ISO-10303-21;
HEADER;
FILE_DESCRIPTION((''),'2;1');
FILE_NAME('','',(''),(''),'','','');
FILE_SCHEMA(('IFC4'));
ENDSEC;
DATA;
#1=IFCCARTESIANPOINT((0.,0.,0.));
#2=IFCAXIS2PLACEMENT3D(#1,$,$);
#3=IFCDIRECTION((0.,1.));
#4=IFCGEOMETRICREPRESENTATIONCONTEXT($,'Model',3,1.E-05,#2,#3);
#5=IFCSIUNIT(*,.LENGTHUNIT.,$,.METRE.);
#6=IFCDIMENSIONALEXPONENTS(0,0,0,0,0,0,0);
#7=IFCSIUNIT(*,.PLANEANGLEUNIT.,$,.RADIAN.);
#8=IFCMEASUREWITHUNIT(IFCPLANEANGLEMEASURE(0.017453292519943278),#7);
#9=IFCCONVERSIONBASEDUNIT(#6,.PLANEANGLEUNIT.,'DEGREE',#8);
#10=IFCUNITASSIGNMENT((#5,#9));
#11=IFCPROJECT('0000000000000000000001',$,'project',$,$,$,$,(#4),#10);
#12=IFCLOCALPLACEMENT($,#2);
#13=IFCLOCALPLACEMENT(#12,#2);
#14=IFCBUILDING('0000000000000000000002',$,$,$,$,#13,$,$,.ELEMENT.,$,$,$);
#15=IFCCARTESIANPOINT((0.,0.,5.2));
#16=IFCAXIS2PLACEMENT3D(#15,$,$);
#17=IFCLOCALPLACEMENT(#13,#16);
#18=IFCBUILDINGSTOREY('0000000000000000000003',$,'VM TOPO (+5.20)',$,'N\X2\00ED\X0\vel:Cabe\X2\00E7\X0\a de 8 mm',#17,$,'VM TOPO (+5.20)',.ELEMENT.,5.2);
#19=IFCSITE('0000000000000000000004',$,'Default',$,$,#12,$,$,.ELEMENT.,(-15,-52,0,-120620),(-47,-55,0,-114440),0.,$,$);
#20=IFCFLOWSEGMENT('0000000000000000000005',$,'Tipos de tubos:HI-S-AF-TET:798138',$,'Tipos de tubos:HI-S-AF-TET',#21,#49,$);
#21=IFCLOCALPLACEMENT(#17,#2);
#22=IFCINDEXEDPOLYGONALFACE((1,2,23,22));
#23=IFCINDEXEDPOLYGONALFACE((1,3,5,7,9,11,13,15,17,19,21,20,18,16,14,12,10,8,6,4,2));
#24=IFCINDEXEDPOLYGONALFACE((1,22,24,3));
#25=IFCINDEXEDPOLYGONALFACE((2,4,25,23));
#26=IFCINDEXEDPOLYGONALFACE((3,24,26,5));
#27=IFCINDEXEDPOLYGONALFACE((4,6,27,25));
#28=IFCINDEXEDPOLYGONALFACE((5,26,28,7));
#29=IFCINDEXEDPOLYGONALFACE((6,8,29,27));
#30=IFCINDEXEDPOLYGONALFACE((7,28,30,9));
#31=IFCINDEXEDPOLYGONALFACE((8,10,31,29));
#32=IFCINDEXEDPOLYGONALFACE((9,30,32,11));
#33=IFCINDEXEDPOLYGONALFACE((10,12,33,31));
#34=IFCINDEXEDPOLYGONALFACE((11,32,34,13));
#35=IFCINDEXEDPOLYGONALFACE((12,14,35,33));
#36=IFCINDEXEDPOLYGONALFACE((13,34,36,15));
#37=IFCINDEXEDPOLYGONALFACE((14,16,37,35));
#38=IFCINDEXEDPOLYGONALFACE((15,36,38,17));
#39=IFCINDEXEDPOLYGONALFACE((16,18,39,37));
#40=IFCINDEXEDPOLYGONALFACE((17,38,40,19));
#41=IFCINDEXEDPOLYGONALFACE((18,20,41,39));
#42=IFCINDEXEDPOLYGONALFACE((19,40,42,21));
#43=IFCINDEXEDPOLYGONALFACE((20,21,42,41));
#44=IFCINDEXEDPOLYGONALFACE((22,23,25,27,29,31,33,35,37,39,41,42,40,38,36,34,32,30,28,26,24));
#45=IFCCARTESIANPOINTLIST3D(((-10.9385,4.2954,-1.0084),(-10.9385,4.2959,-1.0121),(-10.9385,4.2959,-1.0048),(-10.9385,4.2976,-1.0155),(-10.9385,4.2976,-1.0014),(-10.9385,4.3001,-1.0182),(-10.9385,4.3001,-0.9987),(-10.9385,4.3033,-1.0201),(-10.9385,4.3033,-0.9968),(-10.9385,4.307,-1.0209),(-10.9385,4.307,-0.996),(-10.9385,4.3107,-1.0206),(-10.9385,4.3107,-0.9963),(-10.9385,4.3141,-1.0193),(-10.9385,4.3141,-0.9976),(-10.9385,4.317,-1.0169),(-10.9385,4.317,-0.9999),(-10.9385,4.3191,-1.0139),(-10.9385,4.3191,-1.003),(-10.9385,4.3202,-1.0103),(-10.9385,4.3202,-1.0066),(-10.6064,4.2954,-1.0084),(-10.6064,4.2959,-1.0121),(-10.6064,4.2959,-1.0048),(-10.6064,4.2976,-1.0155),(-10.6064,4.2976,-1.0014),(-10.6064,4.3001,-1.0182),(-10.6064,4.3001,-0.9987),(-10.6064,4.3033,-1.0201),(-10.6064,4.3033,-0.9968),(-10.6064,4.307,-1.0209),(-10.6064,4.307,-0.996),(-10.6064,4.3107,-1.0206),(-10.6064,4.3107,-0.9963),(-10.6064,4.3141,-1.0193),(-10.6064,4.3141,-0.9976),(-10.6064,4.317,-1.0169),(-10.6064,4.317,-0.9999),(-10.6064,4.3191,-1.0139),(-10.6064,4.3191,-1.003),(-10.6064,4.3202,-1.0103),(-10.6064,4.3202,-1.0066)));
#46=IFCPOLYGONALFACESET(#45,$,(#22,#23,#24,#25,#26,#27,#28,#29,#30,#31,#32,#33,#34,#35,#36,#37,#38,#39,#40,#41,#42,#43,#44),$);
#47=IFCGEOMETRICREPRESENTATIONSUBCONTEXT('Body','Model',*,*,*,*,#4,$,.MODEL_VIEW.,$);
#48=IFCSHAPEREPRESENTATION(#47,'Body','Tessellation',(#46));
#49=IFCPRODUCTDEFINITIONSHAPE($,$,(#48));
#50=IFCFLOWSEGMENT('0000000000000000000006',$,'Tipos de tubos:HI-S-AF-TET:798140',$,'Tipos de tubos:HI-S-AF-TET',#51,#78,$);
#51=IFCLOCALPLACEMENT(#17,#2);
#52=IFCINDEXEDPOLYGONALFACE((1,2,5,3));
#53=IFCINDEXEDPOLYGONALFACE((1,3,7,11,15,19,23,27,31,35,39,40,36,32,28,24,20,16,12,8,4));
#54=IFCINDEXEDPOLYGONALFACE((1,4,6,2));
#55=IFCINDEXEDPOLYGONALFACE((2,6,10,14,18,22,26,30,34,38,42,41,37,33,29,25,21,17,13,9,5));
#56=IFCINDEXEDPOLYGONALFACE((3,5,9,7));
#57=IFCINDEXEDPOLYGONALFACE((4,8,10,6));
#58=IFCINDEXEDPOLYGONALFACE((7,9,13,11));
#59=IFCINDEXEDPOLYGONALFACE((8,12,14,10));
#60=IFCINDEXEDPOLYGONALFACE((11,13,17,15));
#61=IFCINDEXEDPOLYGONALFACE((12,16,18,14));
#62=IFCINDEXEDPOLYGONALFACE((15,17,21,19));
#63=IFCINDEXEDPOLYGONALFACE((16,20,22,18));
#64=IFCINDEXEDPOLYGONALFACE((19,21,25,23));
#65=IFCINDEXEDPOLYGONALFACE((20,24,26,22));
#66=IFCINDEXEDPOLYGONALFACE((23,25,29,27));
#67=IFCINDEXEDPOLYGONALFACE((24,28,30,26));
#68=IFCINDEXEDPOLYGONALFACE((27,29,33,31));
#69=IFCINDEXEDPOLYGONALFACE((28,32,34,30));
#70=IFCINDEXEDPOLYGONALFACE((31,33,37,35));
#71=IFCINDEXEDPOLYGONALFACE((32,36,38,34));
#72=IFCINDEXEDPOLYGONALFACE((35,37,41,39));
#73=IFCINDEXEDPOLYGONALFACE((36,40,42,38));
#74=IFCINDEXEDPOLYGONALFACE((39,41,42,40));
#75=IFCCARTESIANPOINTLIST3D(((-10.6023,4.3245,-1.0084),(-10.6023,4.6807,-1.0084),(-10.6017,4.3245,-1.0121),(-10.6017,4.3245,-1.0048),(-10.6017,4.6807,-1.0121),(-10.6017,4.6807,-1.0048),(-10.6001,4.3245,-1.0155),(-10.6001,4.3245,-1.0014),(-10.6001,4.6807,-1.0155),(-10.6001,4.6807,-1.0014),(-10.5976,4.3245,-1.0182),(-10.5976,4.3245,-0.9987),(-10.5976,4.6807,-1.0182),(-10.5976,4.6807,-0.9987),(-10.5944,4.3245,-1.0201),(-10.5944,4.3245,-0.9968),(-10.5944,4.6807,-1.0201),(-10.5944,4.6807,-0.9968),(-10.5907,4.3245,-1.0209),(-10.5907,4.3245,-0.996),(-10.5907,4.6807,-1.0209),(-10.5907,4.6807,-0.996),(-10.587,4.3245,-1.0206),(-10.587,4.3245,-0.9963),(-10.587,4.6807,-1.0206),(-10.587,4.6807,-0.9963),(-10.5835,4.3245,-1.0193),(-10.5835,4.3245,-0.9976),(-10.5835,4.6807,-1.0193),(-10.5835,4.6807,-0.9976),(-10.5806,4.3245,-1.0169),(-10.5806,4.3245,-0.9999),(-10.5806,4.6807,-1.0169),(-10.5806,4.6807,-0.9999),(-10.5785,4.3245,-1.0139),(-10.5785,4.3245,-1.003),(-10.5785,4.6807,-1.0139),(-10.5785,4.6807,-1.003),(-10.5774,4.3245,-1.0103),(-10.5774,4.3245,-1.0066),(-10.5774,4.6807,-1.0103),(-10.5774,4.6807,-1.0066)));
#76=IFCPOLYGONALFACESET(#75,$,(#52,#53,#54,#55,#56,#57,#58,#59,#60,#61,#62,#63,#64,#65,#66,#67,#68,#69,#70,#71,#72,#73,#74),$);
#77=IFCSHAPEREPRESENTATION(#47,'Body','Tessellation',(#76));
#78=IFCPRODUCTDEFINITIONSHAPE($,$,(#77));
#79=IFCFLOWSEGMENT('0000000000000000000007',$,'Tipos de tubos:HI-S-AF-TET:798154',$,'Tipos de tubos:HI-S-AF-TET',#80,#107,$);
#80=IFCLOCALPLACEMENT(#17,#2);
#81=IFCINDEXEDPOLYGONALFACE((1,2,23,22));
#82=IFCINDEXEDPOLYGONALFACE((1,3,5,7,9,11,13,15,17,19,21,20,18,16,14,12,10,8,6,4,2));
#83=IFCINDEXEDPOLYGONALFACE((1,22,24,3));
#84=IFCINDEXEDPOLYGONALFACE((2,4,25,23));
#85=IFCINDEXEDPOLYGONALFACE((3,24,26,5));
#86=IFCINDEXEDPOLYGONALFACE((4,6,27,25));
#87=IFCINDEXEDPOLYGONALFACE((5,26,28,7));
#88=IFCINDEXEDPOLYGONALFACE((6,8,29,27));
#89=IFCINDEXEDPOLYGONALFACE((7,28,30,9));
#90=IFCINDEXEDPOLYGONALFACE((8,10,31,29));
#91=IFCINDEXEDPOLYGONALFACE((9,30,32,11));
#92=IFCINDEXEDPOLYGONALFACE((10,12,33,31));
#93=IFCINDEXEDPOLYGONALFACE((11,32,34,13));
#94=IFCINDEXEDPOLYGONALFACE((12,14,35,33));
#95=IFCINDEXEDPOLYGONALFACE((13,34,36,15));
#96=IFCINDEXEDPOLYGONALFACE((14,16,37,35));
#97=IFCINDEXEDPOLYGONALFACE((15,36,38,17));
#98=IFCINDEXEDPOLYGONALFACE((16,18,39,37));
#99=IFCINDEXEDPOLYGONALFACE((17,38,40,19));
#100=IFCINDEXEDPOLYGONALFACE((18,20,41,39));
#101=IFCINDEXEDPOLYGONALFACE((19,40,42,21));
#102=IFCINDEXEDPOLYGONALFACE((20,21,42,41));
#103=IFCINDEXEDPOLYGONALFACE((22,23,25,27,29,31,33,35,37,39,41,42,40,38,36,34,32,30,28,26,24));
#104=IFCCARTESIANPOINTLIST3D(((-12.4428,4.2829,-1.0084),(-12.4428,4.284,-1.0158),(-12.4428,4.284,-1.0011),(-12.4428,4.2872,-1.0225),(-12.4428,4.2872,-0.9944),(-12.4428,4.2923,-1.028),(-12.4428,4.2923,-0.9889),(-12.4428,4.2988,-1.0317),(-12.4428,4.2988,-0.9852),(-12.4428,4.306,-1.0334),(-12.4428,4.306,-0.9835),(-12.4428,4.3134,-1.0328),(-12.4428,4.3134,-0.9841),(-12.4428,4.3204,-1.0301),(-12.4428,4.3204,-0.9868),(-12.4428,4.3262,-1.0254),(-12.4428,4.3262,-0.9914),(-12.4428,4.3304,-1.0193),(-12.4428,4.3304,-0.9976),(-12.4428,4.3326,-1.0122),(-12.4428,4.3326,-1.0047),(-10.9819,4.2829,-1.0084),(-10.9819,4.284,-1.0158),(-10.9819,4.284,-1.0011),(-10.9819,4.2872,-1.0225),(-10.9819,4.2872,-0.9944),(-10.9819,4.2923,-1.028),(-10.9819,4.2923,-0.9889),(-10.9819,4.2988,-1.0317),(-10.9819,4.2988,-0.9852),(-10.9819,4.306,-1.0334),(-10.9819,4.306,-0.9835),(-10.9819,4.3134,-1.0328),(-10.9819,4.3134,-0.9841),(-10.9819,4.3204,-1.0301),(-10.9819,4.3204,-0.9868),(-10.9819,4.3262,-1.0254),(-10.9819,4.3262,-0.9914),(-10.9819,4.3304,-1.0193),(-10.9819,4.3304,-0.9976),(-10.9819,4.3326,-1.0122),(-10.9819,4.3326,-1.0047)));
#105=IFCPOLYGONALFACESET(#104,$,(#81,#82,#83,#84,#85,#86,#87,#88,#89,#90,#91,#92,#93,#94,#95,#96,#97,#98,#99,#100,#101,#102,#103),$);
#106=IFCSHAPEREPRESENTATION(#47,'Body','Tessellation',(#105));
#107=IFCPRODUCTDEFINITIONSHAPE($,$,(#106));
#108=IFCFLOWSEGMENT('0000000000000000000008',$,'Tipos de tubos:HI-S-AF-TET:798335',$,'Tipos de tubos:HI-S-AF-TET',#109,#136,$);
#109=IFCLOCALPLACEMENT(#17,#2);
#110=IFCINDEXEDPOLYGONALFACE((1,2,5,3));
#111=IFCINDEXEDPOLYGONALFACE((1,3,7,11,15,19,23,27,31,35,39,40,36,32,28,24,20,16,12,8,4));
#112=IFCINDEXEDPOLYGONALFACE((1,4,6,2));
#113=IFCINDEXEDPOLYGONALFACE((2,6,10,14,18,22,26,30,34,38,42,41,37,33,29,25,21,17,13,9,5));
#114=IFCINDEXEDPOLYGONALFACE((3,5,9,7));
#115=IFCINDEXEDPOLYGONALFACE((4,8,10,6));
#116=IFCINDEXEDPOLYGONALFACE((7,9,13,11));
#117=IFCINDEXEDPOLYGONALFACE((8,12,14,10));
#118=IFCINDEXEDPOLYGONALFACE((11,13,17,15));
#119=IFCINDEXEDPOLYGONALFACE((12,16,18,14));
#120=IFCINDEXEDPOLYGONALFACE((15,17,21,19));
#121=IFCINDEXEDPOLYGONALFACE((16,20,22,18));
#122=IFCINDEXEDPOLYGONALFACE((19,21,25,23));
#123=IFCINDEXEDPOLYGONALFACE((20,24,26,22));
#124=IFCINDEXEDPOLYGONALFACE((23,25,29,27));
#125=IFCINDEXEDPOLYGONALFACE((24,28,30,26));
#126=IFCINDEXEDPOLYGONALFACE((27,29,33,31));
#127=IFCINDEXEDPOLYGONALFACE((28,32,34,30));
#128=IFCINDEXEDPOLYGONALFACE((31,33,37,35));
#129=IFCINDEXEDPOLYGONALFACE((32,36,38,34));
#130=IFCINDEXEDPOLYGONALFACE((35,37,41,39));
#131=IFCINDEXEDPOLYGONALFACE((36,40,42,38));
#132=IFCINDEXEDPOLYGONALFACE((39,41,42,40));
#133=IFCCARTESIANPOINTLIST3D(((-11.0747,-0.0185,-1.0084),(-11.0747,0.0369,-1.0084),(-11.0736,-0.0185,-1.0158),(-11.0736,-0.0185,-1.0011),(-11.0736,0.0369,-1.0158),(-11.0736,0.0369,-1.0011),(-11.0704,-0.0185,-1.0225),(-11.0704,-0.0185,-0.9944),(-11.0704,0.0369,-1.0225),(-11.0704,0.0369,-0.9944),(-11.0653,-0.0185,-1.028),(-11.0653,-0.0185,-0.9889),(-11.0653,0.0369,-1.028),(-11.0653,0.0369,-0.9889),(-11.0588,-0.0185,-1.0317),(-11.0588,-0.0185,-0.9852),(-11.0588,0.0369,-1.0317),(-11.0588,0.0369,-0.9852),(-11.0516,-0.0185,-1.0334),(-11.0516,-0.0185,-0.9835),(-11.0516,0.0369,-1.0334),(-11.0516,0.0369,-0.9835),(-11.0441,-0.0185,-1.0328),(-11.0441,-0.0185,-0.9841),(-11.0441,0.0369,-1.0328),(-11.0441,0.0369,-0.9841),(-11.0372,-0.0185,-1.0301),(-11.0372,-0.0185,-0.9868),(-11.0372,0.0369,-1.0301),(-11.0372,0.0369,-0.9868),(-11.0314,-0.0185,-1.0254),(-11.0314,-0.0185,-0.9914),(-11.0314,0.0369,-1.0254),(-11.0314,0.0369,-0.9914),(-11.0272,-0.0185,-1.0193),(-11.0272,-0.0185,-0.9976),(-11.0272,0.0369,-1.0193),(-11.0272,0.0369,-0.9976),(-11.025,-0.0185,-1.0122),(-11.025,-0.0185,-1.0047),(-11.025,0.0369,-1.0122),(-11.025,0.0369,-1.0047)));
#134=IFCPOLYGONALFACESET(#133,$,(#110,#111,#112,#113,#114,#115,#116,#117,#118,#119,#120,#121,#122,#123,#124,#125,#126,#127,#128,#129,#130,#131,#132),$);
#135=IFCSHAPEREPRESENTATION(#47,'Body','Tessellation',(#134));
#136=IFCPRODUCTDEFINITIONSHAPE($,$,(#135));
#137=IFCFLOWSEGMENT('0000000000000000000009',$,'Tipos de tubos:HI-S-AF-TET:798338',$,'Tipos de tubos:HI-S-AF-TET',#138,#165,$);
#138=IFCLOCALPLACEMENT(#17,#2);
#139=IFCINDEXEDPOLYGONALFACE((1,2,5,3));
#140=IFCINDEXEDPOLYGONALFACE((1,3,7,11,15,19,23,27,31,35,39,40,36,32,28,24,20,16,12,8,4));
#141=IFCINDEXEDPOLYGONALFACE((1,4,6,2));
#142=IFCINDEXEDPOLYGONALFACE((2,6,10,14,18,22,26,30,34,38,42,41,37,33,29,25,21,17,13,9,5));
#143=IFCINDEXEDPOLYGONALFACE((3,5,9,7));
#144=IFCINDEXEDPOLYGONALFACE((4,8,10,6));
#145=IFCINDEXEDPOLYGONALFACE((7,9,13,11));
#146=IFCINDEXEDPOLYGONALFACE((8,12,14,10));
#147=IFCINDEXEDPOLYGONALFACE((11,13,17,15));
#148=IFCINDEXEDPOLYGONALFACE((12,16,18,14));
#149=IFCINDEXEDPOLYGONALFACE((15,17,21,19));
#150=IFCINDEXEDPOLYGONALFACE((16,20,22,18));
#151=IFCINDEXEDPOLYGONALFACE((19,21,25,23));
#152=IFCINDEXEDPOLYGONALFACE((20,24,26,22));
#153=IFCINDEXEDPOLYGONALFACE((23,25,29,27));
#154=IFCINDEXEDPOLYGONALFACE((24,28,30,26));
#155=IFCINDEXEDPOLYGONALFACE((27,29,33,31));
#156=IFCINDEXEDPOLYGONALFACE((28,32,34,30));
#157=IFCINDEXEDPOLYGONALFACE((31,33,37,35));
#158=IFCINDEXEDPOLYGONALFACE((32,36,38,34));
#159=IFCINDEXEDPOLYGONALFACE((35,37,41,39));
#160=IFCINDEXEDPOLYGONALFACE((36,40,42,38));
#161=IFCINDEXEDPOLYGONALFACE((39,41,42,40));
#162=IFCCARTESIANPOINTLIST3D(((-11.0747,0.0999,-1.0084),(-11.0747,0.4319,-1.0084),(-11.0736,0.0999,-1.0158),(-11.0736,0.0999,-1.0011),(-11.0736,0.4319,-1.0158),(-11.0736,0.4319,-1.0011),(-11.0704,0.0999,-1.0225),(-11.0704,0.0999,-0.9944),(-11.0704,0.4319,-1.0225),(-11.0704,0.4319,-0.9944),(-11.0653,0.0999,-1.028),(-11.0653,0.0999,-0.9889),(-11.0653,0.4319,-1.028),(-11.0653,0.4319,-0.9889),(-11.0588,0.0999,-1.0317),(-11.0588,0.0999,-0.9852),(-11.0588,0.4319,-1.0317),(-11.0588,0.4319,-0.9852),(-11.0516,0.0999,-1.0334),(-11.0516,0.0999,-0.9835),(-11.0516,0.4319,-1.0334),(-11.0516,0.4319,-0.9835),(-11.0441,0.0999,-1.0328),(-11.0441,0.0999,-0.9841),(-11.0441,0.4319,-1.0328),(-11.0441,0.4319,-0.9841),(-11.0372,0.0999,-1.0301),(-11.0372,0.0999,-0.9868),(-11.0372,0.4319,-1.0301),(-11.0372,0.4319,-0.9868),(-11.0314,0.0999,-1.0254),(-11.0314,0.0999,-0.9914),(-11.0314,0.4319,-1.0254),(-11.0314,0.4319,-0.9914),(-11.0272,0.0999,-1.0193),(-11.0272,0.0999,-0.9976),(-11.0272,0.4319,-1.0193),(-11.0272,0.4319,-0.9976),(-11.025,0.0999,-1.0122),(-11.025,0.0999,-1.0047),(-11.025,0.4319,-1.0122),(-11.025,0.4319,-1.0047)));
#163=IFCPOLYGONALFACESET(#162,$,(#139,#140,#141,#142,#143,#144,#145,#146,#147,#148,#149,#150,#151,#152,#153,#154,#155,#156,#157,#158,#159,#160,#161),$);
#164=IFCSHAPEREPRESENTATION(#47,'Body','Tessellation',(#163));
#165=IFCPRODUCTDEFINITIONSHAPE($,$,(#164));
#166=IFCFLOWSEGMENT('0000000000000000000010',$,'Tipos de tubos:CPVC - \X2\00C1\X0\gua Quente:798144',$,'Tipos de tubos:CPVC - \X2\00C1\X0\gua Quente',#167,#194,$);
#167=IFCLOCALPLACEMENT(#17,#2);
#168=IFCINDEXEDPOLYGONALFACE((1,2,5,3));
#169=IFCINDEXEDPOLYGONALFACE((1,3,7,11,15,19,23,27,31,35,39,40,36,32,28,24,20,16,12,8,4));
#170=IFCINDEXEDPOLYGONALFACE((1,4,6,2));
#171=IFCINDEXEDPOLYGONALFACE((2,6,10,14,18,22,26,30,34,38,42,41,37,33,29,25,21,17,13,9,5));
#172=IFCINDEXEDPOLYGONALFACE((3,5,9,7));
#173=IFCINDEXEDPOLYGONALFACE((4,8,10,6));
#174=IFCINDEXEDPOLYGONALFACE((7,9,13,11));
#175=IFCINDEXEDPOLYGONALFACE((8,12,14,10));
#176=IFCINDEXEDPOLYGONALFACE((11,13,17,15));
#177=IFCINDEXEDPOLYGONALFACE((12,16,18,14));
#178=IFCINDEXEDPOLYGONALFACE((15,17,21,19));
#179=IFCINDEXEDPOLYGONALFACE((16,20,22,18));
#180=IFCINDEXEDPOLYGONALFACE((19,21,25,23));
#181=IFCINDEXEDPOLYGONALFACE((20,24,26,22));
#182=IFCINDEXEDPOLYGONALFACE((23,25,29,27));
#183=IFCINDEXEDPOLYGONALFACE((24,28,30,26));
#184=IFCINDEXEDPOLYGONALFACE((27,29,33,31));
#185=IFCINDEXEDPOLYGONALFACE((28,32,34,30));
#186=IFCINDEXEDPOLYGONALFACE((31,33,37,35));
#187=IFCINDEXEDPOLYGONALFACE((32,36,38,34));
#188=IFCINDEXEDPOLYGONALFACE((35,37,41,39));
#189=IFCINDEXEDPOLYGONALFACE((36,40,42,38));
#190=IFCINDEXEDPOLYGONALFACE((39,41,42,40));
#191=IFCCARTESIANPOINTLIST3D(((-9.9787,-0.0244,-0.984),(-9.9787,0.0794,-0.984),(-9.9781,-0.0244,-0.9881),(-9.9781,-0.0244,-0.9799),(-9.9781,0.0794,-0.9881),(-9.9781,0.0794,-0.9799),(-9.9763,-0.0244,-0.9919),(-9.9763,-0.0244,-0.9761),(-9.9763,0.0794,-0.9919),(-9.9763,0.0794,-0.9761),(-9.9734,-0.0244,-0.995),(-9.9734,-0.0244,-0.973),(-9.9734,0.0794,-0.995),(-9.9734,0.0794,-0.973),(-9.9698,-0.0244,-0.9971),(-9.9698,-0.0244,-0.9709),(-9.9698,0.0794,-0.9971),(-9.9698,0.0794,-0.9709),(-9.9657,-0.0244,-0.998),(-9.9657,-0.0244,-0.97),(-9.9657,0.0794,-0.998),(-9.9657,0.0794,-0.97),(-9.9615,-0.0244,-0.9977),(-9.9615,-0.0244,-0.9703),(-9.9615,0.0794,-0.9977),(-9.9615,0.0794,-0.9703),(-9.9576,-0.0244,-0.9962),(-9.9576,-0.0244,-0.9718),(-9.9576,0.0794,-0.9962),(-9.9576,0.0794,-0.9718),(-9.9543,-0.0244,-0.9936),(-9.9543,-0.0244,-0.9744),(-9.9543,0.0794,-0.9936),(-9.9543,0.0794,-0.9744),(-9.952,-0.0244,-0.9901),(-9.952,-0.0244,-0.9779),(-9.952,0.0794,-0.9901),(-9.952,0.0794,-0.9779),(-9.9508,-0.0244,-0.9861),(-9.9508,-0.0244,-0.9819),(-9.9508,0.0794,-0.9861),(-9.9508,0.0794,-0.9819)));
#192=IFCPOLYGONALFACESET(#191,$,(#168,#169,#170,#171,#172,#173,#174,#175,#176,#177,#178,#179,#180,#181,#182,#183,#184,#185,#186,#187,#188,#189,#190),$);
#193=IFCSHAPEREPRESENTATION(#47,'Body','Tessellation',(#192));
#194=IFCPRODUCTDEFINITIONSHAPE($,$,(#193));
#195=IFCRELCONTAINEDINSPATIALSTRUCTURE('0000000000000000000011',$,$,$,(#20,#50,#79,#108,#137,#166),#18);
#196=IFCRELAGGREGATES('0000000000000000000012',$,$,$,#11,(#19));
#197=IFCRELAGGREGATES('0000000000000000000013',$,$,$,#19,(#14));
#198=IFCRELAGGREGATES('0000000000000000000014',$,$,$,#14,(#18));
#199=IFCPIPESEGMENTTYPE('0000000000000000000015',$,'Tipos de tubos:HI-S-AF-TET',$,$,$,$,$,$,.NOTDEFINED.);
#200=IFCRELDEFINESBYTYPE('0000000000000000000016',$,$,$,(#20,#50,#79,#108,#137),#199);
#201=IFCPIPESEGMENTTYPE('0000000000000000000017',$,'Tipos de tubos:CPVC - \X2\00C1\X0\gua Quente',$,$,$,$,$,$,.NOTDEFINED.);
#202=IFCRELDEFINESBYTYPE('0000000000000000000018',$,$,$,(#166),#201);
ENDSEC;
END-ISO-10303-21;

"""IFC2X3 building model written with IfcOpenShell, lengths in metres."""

from ifc_helpers import new_model, entity, si_unit, converted_unit, direction, frame, frame_2d, origin, origin_2d_with_axis, place, context, subcontext, project, spatial, circle, extrude, type_object, element, save


model = new_model("IFC2X3")

# Units and contexts
model_context = context("Model", 3, precision=1e-05, world=origin(), true_north=direction((0.0, 1.0)))
body_context = subcontext(model_context, "Body", "Model", "MODEL_VIEW")
ifc_project = project(units=[si_unit("LENGTHUNIT", "METRE"), converted_unit("PLANEANGLEUNIT", "DEGREE", entity("IfcPlaneAngleMeasure", 0.017453292519943278), si_unit("PLANEANGLEUNIT", "RADIAN"), dimensions=[0, 0, 0, 0, 0, 0, 0])], contexts=[model_context])

# Site, building, storey
site_placement = place(None, origin())
site = spatial("IfcSite", under=ifc_project, at=site_placement, Name="Default", CompositionType="ELEMENT", RefLatitude=(-15, -52, 0, -120620), RefLongitude=(-47, -55, 0, -114440), RefElevation=0.0)
building_placement = place(site_placement, origin())
building = spatial("IfcBuilding", under=site, at=building_placement, CompositionType="ELEMENT")
storey_placement = place(building_placement, frame((0.0, 0.0, 5.2)))
storey = spatial("IfcBuildingStorey", under=building, at=storey_placement, Name="VM TOPO (+5.20)", ObjectType="Nível:Cabeça de 8 mm", LongName="VM TOPO (+5.20)", CompositionType="ELEMENT", Elevation=5.2)

# Flow segments
pipe_segment_type_1 = type_object("IfcPipeSegmentType", Name="Tipos de tubos:HI-S-AF-TET", PredefinedType="NOTDEFINED")
flow_segment_1_placement = place(storey_placement, origin())
element("IfcFlowSegment", 1, at=flow_segment_1_placement, inside=storey, type_object=pipe_segment_type_1, Name="Tipos de tubos:HI-S-AF-TET:798138", ObjectType="Tipos de tubos:HI-S-AF-TET", context=body_context, shape_type="SweptSolid", body=[
    extrude(circle(Radius=0.0125, at=frame_2d((0.0, 0.0), x_axis=(1.0, 0.0))), frame((-10.9385, 4.3079, -1.0084), z_axis=(1.0, 0.0, 0.0), x_axis=(0.0, -1.0, 0.0)), (0.0, 0.0, 1.0), 0.3321),
])
flow_segment_2_placement = place(storey_placement, origin())
element("IfcFlowSegment", 2, at=flow_segment_2_placement, inside=storey, type_object=pipe_segment_type_1, Name="Tipos de tubos:HI-S-AF-TET:798140", ObjectType="Tipos de tubos:HI-S-AF-TET", context=body_context, shape_type="SweptSolid", body=[
    extrude(circle(Radius=0.0125, at=origin_2d_with_axis()), frame((-10.5898, 4.3245, -1.0084), z_axis=(0.0, 1.0, 0.0), x_axis=(-1.0, 0.0, 0.0)), (0.0, 0.0, 1.0), 0.3563),
])
flow_segment_3_placement = place(storey_placement, origin())
element("IfcFlowSegment", 3, at=flow_segment_3_placement, inside=storey, type_object=pipe_segment_type_1, Name="Tipos de tubos:HI-S-AF-TET:798154", ObjectType="Tipos de tubos:HI-S-AF-TET", context=body_context, shape_type="SweptSolid", body=[
    extrude(circle(Radius=0.025, at=origin_2d_with_axis()), frame((-12.4428, 4.3079, -1.0084), z_axis=(1.0, 0.0, 0.0), x_axis=(0.0, -1.0, 0.0)), (0.0, 0.0, 1.0), 1.4609),
])
flow_segment_4_placement = place(storey_placement, origin())
element("IfcFlowSegment", 4, at=flow_segment_4_placement, inside=storey, type_object=pipe_segment_type_1, Name="Tipos de tubos:HI-S-AF-TET:798335", ObjectType="Tipos de tubos:HI-S-AF-TET", context=body_context, shape_type="SweptSolid", body=[
    extrude(circle(Radius=0.025, at=frame_2d((0.0, 0.0), x_axis=(1.0, 0.0))), frame((-11.0497, -0.0185, -1.0084), z_axis=(0.0, 1.0, 0.0), x_axis=(-1.0, 0.0, 0.0)), (0.0, 0.0, 1.0), 0.0554),
])
flow_segment_5_placement = place(storey_placement, origin())
element("IfcFlowSegment", 5, at=flow_segment_5_placement, inside=storey, type_object=pipe_segment_type_1, Name="Tipos de tubos:HI-S-AF-TET:798338", ObjectType="Tipos de tubos:HI-S-AF-TET", context=body_context, shape_type="SweptSolid", body=[
    extrude(circle(Radius=0.025, at=frame_2d((0.0, 0.0), x_axis=(1.0, 0.0))), frame((-11.0497, 0.0999, -1.0084), z_axis=(-0.000011, 1.0, 0.0), x_axis=(-1.0, -0.000011, 0.0)), (0.0, 0.0, 1.0), 0.332),
])
pipe_segment_type_2 = type_object("IfcPipeSegmentType", Name="Tipos de tubos:CPVC - Água Quente", PredefinedType="NOTDEFINED")
flow_segment_6_placement = place(storey_placement, origin())
element("IfcFlowSegment", 6, at=flow_segment_6_placement, inside=storey, type_object=pipe_segment_type_2, Name="Tipos de tubos:CPVC - Água Quente:798144", ObjectType="Tipos de tubos:CPVC - Água Quente", context=body_context, shape_type="SweptSolid", body=[
    extrude(circle(Radius=0.0141, at=frame_2d((0.0, 0.0), x_axis=(1.0, 0.0))), frame((-9.9646, -0.0244, -0.984), z_axis=(0.0, 1.0, 0.0), x_axis=(-1.0, 0.0, 0.0)), (0.0, 0.0, 1.0), 0.1038),
])

save(model, "model.ifc")
